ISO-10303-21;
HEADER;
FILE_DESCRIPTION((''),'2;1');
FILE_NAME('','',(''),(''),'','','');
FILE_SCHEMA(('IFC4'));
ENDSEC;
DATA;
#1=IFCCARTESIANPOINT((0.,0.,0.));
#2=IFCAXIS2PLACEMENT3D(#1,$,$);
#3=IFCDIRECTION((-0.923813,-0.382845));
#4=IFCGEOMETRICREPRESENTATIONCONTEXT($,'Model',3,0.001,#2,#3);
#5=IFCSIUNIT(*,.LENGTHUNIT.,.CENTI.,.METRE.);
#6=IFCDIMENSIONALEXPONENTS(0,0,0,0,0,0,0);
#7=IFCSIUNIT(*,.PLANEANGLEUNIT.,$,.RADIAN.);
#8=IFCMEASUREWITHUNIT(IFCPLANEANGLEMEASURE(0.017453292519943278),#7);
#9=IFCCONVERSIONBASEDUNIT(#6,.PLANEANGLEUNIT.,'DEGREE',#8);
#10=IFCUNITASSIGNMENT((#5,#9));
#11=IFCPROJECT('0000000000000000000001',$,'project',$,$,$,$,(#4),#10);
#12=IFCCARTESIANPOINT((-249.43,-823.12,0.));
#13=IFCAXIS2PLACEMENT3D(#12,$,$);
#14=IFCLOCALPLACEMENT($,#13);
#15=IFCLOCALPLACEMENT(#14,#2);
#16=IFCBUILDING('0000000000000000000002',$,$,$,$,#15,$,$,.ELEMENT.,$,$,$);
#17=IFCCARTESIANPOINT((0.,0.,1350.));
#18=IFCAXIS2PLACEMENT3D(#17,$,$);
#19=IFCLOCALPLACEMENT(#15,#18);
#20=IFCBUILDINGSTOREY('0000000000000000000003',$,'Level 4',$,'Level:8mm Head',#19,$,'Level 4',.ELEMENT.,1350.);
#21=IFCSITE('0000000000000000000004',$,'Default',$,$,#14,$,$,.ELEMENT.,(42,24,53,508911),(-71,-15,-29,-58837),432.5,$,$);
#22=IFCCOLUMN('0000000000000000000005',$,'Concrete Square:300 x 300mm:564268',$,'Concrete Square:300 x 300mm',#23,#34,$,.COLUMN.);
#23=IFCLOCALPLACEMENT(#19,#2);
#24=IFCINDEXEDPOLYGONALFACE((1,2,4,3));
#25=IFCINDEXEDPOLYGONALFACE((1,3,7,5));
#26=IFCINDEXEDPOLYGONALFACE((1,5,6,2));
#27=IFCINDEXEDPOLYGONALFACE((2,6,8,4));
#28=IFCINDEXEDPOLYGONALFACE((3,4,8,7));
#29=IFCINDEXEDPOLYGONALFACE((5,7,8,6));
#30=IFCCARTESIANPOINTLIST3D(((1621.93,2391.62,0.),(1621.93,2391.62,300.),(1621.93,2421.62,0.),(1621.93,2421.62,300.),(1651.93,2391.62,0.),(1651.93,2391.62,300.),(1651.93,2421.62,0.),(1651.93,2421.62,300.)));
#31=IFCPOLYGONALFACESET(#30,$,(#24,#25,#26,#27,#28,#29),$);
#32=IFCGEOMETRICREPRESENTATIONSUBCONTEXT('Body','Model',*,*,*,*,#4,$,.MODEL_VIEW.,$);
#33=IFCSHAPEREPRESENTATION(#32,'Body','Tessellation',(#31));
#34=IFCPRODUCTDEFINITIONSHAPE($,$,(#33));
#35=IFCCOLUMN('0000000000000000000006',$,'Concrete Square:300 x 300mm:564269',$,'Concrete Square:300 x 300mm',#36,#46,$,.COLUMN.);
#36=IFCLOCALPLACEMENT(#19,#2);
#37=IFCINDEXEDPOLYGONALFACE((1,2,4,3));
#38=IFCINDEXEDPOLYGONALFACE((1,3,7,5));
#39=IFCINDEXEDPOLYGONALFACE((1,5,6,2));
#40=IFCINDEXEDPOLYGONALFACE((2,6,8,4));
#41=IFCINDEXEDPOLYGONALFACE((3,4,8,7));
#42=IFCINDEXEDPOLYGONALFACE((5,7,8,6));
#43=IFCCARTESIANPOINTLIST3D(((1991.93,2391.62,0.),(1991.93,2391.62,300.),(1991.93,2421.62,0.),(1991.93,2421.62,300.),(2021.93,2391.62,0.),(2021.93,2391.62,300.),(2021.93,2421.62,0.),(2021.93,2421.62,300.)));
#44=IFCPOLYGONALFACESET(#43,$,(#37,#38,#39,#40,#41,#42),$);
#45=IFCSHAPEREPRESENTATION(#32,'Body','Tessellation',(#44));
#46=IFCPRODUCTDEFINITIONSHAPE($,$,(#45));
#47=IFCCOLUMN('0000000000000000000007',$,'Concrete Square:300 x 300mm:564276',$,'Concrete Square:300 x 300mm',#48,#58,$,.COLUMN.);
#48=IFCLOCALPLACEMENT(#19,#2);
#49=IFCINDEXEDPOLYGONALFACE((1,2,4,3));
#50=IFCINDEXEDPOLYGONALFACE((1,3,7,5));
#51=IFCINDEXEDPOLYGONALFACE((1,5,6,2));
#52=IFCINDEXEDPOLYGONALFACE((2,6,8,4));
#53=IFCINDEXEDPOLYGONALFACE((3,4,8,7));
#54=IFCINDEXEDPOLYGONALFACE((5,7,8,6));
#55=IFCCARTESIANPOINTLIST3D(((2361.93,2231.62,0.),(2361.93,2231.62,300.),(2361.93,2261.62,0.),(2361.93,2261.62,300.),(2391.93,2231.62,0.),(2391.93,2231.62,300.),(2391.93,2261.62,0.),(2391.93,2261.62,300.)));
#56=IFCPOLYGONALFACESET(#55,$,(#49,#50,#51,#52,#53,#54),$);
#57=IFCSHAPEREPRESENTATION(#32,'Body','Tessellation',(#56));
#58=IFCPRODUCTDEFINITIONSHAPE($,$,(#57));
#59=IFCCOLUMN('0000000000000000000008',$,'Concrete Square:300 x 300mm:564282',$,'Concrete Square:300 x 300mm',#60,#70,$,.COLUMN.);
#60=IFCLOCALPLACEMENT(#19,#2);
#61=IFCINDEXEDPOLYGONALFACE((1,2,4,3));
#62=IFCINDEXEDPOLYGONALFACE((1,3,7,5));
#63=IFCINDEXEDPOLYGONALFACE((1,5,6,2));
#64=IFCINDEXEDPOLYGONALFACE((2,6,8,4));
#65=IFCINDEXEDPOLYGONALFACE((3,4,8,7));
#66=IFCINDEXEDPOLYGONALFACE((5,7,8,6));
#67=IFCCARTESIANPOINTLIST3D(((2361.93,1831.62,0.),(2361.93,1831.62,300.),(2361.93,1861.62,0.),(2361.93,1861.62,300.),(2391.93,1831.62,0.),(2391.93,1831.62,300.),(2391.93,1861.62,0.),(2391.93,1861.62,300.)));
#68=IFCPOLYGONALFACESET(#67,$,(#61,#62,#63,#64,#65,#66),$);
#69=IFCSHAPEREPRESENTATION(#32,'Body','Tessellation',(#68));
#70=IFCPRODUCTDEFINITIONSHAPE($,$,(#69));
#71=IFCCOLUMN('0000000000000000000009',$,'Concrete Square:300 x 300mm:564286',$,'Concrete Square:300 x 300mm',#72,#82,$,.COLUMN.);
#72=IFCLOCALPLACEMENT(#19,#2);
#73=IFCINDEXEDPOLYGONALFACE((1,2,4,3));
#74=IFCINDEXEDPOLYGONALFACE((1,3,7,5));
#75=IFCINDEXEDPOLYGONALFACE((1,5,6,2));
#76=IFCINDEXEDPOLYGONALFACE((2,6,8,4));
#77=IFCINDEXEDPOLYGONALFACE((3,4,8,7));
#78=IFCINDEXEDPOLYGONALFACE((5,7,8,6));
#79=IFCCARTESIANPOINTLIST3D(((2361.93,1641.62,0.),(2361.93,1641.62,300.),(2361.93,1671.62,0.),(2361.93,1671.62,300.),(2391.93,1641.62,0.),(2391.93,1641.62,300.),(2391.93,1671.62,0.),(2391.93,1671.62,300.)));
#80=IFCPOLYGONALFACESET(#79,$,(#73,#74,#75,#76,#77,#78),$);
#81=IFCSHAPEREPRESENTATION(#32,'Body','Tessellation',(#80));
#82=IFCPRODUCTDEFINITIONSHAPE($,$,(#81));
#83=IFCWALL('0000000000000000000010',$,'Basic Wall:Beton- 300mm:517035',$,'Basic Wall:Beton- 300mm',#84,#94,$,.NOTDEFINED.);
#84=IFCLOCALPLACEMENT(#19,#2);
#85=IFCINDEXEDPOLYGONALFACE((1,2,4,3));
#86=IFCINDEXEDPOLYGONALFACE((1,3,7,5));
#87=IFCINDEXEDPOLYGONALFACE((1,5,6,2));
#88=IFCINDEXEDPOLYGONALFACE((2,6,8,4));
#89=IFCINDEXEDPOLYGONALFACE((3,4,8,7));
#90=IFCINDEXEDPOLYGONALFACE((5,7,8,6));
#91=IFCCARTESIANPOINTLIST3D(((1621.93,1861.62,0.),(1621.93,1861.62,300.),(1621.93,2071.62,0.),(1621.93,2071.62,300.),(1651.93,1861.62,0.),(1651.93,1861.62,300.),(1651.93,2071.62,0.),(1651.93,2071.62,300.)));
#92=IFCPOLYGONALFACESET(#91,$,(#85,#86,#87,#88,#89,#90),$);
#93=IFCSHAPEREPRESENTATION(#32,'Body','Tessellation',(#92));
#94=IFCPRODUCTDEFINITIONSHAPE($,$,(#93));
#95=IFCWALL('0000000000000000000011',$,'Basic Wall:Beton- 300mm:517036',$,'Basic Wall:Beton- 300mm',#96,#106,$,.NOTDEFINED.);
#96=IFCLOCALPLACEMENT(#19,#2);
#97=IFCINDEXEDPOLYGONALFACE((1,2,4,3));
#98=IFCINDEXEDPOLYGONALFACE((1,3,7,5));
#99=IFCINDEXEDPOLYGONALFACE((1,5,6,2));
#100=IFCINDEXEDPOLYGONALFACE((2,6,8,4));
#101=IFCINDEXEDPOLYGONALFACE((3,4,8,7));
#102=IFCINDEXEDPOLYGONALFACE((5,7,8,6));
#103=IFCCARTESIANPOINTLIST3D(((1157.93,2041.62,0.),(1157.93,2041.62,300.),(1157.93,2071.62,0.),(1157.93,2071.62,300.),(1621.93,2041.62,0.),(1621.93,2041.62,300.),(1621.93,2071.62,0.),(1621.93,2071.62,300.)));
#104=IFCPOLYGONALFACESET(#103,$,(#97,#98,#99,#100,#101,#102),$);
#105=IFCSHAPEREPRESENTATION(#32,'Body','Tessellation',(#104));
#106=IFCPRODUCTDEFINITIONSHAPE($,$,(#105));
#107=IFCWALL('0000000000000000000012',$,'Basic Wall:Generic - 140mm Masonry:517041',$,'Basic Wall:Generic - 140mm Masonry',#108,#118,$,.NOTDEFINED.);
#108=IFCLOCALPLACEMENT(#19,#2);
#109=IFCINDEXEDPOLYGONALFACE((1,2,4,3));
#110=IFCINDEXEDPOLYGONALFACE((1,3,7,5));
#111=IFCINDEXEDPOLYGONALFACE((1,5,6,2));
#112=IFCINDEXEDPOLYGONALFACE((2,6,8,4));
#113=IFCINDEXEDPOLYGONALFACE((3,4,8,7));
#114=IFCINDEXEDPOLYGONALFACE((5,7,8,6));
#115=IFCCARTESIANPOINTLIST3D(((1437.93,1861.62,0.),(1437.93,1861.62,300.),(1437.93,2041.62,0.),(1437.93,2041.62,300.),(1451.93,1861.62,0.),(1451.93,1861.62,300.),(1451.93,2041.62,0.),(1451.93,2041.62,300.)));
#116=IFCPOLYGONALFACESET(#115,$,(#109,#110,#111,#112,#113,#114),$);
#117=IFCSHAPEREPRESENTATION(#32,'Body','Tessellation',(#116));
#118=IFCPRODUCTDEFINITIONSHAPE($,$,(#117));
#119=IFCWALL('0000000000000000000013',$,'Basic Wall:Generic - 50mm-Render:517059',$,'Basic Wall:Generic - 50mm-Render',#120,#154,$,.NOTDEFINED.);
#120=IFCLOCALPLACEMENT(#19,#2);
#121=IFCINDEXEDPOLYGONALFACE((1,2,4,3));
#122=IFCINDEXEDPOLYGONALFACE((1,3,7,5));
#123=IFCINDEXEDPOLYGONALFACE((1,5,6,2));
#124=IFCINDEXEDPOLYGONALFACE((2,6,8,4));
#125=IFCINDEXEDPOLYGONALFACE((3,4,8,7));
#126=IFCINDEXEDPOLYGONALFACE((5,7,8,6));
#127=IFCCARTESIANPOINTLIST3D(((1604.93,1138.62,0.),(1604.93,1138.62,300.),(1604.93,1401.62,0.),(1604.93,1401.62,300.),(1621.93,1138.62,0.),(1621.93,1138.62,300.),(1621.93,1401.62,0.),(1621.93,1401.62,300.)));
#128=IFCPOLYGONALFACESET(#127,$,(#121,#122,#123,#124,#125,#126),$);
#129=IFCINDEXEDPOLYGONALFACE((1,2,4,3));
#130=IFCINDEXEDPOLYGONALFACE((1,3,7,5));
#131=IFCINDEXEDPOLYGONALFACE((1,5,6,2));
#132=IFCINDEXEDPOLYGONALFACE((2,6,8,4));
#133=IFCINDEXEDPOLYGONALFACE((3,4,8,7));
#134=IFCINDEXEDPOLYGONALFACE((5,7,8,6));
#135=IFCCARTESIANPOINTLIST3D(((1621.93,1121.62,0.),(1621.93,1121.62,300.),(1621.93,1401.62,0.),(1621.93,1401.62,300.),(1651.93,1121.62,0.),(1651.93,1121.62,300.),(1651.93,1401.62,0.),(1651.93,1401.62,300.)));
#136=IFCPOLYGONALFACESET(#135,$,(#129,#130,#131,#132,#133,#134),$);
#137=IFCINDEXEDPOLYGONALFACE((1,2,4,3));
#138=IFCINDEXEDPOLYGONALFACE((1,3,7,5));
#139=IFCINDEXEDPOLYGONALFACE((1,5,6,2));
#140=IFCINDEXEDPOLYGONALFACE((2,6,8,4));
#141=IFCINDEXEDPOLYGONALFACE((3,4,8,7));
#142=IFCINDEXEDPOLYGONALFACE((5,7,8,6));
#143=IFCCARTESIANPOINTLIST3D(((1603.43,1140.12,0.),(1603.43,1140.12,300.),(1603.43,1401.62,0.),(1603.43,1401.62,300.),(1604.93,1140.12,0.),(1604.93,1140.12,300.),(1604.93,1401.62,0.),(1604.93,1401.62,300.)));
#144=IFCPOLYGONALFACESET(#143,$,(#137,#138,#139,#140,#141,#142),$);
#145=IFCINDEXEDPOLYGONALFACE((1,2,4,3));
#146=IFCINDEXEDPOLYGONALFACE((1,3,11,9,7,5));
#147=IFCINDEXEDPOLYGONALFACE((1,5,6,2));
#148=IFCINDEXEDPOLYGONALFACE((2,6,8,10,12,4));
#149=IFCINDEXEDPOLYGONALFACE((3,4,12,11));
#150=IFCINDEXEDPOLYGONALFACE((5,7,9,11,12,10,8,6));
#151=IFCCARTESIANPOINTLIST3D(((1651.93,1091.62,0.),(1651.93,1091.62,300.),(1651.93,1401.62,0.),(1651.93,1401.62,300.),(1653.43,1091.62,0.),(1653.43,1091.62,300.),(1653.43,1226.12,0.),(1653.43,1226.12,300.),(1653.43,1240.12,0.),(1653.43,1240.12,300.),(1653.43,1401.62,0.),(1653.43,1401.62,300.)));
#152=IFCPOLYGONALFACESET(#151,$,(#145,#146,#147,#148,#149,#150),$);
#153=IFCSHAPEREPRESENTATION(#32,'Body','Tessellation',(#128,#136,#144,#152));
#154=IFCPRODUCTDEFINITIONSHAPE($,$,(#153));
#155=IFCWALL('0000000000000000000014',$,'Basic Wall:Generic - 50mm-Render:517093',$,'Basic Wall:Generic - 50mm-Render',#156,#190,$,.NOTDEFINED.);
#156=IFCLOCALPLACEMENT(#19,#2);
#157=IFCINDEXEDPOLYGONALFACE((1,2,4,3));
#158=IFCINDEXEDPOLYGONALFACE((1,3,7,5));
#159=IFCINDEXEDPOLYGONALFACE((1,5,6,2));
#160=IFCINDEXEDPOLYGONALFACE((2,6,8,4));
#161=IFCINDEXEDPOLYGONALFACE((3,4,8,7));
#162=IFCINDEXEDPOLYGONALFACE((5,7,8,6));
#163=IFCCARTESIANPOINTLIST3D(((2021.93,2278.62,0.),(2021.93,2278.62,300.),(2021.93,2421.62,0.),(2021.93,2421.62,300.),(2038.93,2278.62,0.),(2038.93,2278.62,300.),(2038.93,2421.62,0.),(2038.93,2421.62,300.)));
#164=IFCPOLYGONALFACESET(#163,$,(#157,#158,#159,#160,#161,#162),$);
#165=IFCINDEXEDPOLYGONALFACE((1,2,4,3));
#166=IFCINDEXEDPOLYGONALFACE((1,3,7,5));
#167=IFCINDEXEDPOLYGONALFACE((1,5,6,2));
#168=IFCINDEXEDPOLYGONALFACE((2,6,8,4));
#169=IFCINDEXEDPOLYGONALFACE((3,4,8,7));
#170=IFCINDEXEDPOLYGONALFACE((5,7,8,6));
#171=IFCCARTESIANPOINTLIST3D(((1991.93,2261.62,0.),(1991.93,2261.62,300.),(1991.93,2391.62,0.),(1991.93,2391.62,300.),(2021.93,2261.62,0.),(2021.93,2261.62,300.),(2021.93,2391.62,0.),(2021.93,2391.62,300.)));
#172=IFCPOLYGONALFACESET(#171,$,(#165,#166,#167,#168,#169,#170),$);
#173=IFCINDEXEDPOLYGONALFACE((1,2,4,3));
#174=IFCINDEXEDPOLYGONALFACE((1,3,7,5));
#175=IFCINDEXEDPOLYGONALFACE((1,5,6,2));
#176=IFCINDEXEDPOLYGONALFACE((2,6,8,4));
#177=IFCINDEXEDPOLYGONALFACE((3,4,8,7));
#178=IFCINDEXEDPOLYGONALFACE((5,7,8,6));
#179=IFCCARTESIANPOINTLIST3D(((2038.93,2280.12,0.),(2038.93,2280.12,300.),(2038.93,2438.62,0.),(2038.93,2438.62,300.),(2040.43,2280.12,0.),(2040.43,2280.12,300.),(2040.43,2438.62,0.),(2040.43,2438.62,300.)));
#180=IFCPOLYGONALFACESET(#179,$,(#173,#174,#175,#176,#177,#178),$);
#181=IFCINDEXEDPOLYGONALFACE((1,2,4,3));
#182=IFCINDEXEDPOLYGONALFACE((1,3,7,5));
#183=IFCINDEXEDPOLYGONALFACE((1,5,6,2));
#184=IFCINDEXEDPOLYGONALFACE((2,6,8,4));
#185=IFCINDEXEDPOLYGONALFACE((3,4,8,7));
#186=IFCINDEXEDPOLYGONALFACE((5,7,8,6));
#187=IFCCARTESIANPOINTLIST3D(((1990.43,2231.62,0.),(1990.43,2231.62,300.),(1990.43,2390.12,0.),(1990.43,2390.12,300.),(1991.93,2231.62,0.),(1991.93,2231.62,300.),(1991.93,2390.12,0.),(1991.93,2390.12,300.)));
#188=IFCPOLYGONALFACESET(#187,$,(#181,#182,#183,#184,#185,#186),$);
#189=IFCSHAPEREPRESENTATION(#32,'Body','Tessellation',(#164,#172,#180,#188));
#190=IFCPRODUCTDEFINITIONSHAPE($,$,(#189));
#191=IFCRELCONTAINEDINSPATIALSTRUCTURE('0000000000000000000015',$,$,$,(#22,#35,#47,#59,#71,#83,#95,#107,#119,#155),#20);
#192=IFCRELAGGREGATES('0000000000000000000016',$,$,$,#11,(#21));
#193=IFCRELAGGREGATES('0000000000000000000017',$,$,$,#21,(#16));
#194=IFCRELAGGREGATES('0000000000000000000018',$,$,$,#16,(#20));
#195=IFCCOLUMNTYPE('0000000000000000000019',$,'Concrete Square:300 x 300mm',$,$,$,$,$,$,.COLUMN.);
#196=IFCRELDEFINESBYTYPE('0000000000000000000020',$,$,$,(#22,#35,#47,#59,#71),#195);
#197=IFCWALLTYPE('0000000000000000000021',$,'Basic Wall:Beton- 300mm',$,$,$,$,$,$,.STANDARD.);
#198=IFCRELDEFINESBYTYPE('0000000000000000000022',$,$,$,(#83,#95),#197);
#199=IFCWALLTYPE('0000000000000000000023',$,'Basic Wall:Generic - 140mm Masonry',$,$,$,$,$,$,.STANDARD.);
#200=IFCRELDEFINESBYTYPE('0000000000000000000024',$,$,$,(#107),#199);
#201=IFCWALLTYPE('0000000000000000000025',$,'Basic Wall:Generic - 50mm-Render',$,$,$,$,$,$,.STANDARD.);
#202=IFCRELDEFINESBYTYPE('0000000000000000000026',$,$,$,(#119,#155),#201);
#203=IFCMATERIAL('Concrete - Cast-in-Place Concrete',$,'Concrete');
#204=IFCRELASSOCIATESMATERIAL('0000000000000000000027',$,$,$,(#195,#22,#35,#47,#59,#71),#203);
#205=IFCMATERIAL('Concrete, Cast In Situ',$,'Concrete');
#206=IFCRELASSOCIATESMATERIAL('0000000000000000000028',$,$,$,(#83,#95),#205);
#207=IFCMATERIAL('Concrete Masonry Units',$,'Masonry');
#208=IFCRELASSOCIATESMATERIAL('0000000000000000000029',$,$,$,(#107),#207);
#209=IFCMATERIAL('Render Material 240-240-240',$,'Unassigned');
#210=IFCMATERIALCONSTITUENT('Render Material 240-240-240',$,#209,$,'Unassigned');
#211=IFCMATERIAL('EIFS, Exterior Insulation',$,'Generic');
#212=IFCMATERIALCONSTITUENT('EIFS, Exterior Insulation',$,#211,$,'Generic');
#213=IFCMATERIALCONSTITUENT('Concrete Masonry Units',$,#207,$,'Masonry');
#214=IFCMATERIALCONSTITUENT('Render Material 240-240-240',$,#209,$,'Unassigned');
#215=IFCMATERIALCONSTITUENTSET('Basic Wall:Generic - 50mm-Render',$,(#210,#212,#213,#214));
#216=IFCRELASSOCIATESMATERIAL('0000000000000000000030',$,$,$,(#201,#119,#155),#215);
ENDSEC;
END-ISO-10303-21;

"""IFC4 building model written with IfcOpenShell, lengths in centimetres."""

from ifc_helpers import new_model, entity, si_unit, converted_unit, direction, frame, origin, place, context, subcontext, project, spatial, indexed_curve, outline, extrude, source, transform, mapped, material, constituent, constituent_set, type_object, type_shapes, element, save


model = new_model("IFC4")

# Units and contexts
model_context = context("Model", 3, precision=0.001, world=origin(), true_north=direction((-0.923813, -0.382845)))
body_context = subcontext(model_context, "Body", "Model", "MODEL_VIEW")
ifc_project = project(units=[si_unit("LENGTHUNIT", "METRE", prefix="CENTI"), converted_unit("PLANEANGLEUNIT", "DEGREE", entity("IfcPlaneAngleMeasure", 0.017453292519943278), si_unit("PLANEANGLEUNIT", "RADIAN"), dimensions=[0, 0, 0, 0, 0, 0, 0])], contexts=[model_context])

# Site, building, storey
site_placement = place(None, frame((-249.43, -823.12, 0.0)))
site = spatial("IfcSite", under=ifc_project, at=site_placement, Name="Default", CompositionType="ELEMENT", RefLatitude=(42, 24, 53, 508911), RefLongitude=(-71, -15, -29, -58837), RefElevation=432.5)
building_placement = place(site_placement, origin())
building = spatial("IfcBuilding", under=site, at=building_placement, CompositionType="ELEMENT")
storey_placement = place(building_placement, frame((0.0, 0.0, 1350.0)))
storey = spatial("IfcBuildingStorey", under=building, at=storey_placement, Name="Level 4", ObjectType="Level:8mm Head", LongName="Level 4", CompositionType="ELEMENT", Elevation=1350.0)

# Columns
ifc_material_1 = material(Name="Concrete - Cast-in-Place Concrete", Category="Concrete")
column_type = type_object("IfcColumnType", Name="Concrete Square:300 x 300mm", PredefinedType="COLUMN", material=ifc_material_1)
shared_shape_1 = source(origin(), body_context, "Body", "SweptSolid", [
    extrude(outline(indexed_curve([(-15.0, -15.0), (15.0, -15.0), (15.0, 15.0), (-15.0, 15.0), (-15.0, -15.0)], self_intersect=False)), frame((0.0, 0.0, 1350.0), z_axis=(0.0, 0.0, 1.0), x_axis=(-1.0, 0.0, 0.0)), (0.0, 0.0, 1.0), 300.0),
])
type_shapes(column_type, [shared_shape_1])
for number, where, name in (
    (1, (1636.93, 2406.62, -1350.0), "Concrete Square:300 x 300mm:564268"),
    (2, (2006.93, 2406.62, -1350.0), "Concrete Square:300 x 300mm:564269"),
    (3, (2376.93, 2246.62, -1350.0), "Concrete Square:300 x 300mm:564276"),
    (4, (2376.93, 1846.62, -1350.0), "Concrete Square:300 x 300mm:564282"),
    (5, (2376.93, 1656.62, -1350.0), "Concrete Square:300 x 300mm:564286"),
):
    element("IfcColumn", number, at=place(storey_placement, frame(where)), inside=storey, type_object=column_type, material=ifc_material_1, Name=name, ObjectType="Concrete Square:300 x 300mm", PredefinedType="COLUMN", context=body_context, shape_type="MappedRepresentation", body=[
        mapped(shared_shape_1, transform((0.0, 0.0, 0.0), scale=1.0)),
    ])

# Walls
ifc_material_2 = material(Name="Concrete, Cast In Situ", Category="Concrete")
wall_type_1 = type_object("IfcWallType", Name="Basic Wall:Beton- 300mm", PredefinedType="STANDARD")
wall_1_placement = place(storey_placement, frame((1636.93, 1861.62, 0.0), z_axis=(0.0, 0.0, 1.0), x_axis=(0.0, 1.0, 0.0)))
element("IfcWall", 6, at=wall_1_placement, inside=storey, type_object=wall_type_1, material=ifc_material_2, Name="Basic Wall:Beton- 300mm:517035", ObjectType="Basic Wall:Beton- 300mm", PredefinedType="NOTDEFINED", context=body_context, shape_type="SweptSolid", body=[
    extrude(outline(indexed_curve([(210.0, 15.0), (0.0, 15.0), (0.0, -15.0), (210.0, -15.0), (210.0, 15.0)], self_intersect=False)), origin(), (0.0, 0.0, 1.0), 300.0),
])
wall_2_placement = place(storey_placement, frame((1621.93, 2056.62, 0.0), z_axis=(0.0, 0.0, 1.0), x_axis=(-1.0, 0.0, 0.0)))
element("IfcWall", 7, at=wall_2_placement, inside=storey, type_object=wall_type_1, material=ifc_material_2, Name="Basic Wall:Beton- 300mm:517036", ObjectType="Basic Wall:Beton- 300mm", PredefinedType="NOTDEFINED", context=body_context, shape_type="SweptSolid", body=[
    extrude(outline(indexed_curve([(464.0, 15.0), (0.0, 15.0), (0.0, -15.0), (464.0, -15.0), (464.0, 15.0)], self_intersect=False)), origin(), (0.0, 0.0, 1.0), 300.0),
])
ifc_material_3 = material(Name="Concrete Masonry Units", Category="Masonry")
wall_type_2 = type_object("IfcWallType", Name="Basic Wall:Generic - 140mm Masonry", PredefinedType="STANDARD")
wall_3_placement = place(storey_placement, frame((1444.93, 2041.62, 0.0), z_axis=(0.0, 0.0, 1.0), x_axis=(0.0, -1.0, 0.0)))
element("IfcWall", 8, at=wall_3_placement, inside=storey, type_object=wall_type_2, material=ifc_material_3, Name="Basic Wall:Generic - 140mm Masonry:517041", ObjectType="Basic Wall:Generic - 140mm Masonry", PredefinedType="NOTDEFINED", context=body_context, shape_type="SweptSolid", body=[
    extrude(outline(indexed_curve([(180.0, 7.0), (0.0, 7.0), (0.0, -7.0), (180.0, -7.0), (180.0, 7.0)], self_intersect=False)), origin(), (0.0, 0.0, 1.0), 300.0),
])
ifc_material_4 = material(Name="Render Material 240-240-240", Category="Unassigned")
ifc_constituent_1 = constituent(ifc_material_4, Name="Render Material 240-240-240", Category="Unassigned")
ifc_material_5 = material(Name="EIFS, Exterior Insulation", Category="Generic")
ifc_constituent_2 = constituent(ifc_material_5, Name="EIFS, Exterior Insulation", Category="Generic")
ifc_constituent_3 = constituent(ifc_material_3, Name="Concrete Masonry Units", Category="Masonry")
ifc_constituent_4 = constituent(ifc_material_4, Name="Render Material 240-240-240", Category="Unassigned")
ifc_constituent_set_1 = constituent_set(constituents=[ifc_constituent_1, ifc_constituent_2, ifc_constituent_3, ifc_constituent_4], Name="Basic Wall:Generic - 50mm-Render")
wall_type_3 = type_object("IfcWallType", Name="Basic Wall:Generic - 50mm-Render", PredefinedType="STANDARD", material=ifc_constituent_set_1)
wall_4_placement = place(storey_placement, frame((1628.43, 1401.62, 0.0), z_axis=(0.0, 0.0, 1.0), x_axis=(0.0, -1.0, 0.0)))
element("IfcWall", 9, at=wall_4_placement, inside=storey, type_object=wall_type_3, material=ifc_constituent_set_1, Name="Basic Wall:Generic - 50mm-Render:517059", ObjectType="Basic Wall:Generic - 50mm-Render", PredefinedType="NOTDEFINED", context=body_context, shape_type="SweptSolid", body=[
    extrude(outline(indexed_curve([(-8.5, -131.5), (8.5, -131.5), (8.5, 131.5), (-8.5, 131.5), (-8.5, -131.5)], self_intersect=False)), frame((131.5, -15.0, 0.0), z_axis=(0.0, 0.0, 1.0), x_axis=(0.0, 1.0, 0.0)), (0.0, 0.0, 1.0), 300.0),
    extrude(outline(indexed_curve([(-15.0, -140.0), (15.0, -140.0), (15.0, 140.0), (-15.0, 140.0), (-15.0, -140.0)], self_intersect=False)), frame((140.0, 8.5, 0.0), z_axis=(0.0, 0.0, 1.0), x_axis=(0.0, -1.0, 0.0)), (0.0, 0.0, 1.0), 300.0),
    extrude(outline(indexed_curve([(-0.75, -130.75), (0.75, -130.75), (0.75, 130.75), (-0.75, 130.75), (-0.75, -130.75)], self_intersect=False)), frame((130.75, -24.25, 0.0), z_axis=(0.0, 0.0, 1.0), x_axis=(0.0, 1.0, 0.0)), (0.0, 0.0, 1.0), 300.0),
    extrude(outline(indexed_curve([(-1.0, -150.5), (0.5, -150.5), (0.5, -16.0), (0.5, -2.0), (0.5, 159.5), (-1.0, 159.5), (-1.0, -150.5)], self_intersect=False)), frame((159.5, 24.5, 0.0), z_axis=(0.0, 0.0, 1.0), x_axis=(0.0, 1.0, 0.0)), (0.0, 0.0, 1.0), 300.0),
])
wall_5_placement = place(storey_placement, frame((2015.43, 2280.12, 0.0), z_axis=(0.0, 0.0, 1.0), x_axis=(0.0, 1.0, 0.0)))
element("IfcWall", 10, at=wall_5_placement, inside=storey, type_object=wall_type_3, material=ifc_constituent_set_1, Name="Basic Wall:Generic - 50mm-Render:517093", ObjectType="Basic Wall:Generic - 50mm-Render", PredefinedType="NOTDEFINED", context=body_context, shape_type="SweptSolid", body=[
    extrude(outline(indexed_curve([(-8.5, -71.5), (8.5, -71.5), (8.5, 71.5), (-8.5, 71.5), (-8.5, -71.5)], self_intersect=False)), frame((70.0, -15.0, 0.0), z_axis=(0.0, 0.0, 1.0), x_axis=(0.0, 1.0, 0.0)), (0.0, 0.0, 1.0), 300.0),
    extrude(outline(indexed_curve([(-15.0, -65.0), (15.0, -65.0), (15.0, 65.0), (-15.0, 65.0), (-15.0, -65.0)], self_intersect=False)), frame((46.5, 8.5, 0.0), z_axis=(0.0, 0.0, 1.0), x_axis=(0.0, -1.0, 0.0)), (0.0, 0.0, 1.0), 300.0),
    extrude(outline(indexed_curve([(-0.75, -79.25), (0.75, -79.25), (0.75, 79.25), (-0.75, 79.25), (-0.75, -79.25)], self_intersect=False)), frame((79.25, -24.25, 0.0), z_axis=(0.0, 0.0, 1.0), x_axis=(0.0, 1.0, 0.0)), (0.0, 0.0, 1.0), 300.0),
    extrude(outline(indexed_curve([(-0.75, -79.25), (0.75, -79.25), (0.75, 79.25), (-0.75, 79.25), (-0.75, -79.25)], self_intersect=False)), frame((30.75, 24.25, 0.0), z_axis=(0.0, 0.0, 1.0), x_axis=(0.0, 1.0, 0.0)), (0.0, 0.0, 1.0), 300.0),
])

save(model, "model.ifc")
